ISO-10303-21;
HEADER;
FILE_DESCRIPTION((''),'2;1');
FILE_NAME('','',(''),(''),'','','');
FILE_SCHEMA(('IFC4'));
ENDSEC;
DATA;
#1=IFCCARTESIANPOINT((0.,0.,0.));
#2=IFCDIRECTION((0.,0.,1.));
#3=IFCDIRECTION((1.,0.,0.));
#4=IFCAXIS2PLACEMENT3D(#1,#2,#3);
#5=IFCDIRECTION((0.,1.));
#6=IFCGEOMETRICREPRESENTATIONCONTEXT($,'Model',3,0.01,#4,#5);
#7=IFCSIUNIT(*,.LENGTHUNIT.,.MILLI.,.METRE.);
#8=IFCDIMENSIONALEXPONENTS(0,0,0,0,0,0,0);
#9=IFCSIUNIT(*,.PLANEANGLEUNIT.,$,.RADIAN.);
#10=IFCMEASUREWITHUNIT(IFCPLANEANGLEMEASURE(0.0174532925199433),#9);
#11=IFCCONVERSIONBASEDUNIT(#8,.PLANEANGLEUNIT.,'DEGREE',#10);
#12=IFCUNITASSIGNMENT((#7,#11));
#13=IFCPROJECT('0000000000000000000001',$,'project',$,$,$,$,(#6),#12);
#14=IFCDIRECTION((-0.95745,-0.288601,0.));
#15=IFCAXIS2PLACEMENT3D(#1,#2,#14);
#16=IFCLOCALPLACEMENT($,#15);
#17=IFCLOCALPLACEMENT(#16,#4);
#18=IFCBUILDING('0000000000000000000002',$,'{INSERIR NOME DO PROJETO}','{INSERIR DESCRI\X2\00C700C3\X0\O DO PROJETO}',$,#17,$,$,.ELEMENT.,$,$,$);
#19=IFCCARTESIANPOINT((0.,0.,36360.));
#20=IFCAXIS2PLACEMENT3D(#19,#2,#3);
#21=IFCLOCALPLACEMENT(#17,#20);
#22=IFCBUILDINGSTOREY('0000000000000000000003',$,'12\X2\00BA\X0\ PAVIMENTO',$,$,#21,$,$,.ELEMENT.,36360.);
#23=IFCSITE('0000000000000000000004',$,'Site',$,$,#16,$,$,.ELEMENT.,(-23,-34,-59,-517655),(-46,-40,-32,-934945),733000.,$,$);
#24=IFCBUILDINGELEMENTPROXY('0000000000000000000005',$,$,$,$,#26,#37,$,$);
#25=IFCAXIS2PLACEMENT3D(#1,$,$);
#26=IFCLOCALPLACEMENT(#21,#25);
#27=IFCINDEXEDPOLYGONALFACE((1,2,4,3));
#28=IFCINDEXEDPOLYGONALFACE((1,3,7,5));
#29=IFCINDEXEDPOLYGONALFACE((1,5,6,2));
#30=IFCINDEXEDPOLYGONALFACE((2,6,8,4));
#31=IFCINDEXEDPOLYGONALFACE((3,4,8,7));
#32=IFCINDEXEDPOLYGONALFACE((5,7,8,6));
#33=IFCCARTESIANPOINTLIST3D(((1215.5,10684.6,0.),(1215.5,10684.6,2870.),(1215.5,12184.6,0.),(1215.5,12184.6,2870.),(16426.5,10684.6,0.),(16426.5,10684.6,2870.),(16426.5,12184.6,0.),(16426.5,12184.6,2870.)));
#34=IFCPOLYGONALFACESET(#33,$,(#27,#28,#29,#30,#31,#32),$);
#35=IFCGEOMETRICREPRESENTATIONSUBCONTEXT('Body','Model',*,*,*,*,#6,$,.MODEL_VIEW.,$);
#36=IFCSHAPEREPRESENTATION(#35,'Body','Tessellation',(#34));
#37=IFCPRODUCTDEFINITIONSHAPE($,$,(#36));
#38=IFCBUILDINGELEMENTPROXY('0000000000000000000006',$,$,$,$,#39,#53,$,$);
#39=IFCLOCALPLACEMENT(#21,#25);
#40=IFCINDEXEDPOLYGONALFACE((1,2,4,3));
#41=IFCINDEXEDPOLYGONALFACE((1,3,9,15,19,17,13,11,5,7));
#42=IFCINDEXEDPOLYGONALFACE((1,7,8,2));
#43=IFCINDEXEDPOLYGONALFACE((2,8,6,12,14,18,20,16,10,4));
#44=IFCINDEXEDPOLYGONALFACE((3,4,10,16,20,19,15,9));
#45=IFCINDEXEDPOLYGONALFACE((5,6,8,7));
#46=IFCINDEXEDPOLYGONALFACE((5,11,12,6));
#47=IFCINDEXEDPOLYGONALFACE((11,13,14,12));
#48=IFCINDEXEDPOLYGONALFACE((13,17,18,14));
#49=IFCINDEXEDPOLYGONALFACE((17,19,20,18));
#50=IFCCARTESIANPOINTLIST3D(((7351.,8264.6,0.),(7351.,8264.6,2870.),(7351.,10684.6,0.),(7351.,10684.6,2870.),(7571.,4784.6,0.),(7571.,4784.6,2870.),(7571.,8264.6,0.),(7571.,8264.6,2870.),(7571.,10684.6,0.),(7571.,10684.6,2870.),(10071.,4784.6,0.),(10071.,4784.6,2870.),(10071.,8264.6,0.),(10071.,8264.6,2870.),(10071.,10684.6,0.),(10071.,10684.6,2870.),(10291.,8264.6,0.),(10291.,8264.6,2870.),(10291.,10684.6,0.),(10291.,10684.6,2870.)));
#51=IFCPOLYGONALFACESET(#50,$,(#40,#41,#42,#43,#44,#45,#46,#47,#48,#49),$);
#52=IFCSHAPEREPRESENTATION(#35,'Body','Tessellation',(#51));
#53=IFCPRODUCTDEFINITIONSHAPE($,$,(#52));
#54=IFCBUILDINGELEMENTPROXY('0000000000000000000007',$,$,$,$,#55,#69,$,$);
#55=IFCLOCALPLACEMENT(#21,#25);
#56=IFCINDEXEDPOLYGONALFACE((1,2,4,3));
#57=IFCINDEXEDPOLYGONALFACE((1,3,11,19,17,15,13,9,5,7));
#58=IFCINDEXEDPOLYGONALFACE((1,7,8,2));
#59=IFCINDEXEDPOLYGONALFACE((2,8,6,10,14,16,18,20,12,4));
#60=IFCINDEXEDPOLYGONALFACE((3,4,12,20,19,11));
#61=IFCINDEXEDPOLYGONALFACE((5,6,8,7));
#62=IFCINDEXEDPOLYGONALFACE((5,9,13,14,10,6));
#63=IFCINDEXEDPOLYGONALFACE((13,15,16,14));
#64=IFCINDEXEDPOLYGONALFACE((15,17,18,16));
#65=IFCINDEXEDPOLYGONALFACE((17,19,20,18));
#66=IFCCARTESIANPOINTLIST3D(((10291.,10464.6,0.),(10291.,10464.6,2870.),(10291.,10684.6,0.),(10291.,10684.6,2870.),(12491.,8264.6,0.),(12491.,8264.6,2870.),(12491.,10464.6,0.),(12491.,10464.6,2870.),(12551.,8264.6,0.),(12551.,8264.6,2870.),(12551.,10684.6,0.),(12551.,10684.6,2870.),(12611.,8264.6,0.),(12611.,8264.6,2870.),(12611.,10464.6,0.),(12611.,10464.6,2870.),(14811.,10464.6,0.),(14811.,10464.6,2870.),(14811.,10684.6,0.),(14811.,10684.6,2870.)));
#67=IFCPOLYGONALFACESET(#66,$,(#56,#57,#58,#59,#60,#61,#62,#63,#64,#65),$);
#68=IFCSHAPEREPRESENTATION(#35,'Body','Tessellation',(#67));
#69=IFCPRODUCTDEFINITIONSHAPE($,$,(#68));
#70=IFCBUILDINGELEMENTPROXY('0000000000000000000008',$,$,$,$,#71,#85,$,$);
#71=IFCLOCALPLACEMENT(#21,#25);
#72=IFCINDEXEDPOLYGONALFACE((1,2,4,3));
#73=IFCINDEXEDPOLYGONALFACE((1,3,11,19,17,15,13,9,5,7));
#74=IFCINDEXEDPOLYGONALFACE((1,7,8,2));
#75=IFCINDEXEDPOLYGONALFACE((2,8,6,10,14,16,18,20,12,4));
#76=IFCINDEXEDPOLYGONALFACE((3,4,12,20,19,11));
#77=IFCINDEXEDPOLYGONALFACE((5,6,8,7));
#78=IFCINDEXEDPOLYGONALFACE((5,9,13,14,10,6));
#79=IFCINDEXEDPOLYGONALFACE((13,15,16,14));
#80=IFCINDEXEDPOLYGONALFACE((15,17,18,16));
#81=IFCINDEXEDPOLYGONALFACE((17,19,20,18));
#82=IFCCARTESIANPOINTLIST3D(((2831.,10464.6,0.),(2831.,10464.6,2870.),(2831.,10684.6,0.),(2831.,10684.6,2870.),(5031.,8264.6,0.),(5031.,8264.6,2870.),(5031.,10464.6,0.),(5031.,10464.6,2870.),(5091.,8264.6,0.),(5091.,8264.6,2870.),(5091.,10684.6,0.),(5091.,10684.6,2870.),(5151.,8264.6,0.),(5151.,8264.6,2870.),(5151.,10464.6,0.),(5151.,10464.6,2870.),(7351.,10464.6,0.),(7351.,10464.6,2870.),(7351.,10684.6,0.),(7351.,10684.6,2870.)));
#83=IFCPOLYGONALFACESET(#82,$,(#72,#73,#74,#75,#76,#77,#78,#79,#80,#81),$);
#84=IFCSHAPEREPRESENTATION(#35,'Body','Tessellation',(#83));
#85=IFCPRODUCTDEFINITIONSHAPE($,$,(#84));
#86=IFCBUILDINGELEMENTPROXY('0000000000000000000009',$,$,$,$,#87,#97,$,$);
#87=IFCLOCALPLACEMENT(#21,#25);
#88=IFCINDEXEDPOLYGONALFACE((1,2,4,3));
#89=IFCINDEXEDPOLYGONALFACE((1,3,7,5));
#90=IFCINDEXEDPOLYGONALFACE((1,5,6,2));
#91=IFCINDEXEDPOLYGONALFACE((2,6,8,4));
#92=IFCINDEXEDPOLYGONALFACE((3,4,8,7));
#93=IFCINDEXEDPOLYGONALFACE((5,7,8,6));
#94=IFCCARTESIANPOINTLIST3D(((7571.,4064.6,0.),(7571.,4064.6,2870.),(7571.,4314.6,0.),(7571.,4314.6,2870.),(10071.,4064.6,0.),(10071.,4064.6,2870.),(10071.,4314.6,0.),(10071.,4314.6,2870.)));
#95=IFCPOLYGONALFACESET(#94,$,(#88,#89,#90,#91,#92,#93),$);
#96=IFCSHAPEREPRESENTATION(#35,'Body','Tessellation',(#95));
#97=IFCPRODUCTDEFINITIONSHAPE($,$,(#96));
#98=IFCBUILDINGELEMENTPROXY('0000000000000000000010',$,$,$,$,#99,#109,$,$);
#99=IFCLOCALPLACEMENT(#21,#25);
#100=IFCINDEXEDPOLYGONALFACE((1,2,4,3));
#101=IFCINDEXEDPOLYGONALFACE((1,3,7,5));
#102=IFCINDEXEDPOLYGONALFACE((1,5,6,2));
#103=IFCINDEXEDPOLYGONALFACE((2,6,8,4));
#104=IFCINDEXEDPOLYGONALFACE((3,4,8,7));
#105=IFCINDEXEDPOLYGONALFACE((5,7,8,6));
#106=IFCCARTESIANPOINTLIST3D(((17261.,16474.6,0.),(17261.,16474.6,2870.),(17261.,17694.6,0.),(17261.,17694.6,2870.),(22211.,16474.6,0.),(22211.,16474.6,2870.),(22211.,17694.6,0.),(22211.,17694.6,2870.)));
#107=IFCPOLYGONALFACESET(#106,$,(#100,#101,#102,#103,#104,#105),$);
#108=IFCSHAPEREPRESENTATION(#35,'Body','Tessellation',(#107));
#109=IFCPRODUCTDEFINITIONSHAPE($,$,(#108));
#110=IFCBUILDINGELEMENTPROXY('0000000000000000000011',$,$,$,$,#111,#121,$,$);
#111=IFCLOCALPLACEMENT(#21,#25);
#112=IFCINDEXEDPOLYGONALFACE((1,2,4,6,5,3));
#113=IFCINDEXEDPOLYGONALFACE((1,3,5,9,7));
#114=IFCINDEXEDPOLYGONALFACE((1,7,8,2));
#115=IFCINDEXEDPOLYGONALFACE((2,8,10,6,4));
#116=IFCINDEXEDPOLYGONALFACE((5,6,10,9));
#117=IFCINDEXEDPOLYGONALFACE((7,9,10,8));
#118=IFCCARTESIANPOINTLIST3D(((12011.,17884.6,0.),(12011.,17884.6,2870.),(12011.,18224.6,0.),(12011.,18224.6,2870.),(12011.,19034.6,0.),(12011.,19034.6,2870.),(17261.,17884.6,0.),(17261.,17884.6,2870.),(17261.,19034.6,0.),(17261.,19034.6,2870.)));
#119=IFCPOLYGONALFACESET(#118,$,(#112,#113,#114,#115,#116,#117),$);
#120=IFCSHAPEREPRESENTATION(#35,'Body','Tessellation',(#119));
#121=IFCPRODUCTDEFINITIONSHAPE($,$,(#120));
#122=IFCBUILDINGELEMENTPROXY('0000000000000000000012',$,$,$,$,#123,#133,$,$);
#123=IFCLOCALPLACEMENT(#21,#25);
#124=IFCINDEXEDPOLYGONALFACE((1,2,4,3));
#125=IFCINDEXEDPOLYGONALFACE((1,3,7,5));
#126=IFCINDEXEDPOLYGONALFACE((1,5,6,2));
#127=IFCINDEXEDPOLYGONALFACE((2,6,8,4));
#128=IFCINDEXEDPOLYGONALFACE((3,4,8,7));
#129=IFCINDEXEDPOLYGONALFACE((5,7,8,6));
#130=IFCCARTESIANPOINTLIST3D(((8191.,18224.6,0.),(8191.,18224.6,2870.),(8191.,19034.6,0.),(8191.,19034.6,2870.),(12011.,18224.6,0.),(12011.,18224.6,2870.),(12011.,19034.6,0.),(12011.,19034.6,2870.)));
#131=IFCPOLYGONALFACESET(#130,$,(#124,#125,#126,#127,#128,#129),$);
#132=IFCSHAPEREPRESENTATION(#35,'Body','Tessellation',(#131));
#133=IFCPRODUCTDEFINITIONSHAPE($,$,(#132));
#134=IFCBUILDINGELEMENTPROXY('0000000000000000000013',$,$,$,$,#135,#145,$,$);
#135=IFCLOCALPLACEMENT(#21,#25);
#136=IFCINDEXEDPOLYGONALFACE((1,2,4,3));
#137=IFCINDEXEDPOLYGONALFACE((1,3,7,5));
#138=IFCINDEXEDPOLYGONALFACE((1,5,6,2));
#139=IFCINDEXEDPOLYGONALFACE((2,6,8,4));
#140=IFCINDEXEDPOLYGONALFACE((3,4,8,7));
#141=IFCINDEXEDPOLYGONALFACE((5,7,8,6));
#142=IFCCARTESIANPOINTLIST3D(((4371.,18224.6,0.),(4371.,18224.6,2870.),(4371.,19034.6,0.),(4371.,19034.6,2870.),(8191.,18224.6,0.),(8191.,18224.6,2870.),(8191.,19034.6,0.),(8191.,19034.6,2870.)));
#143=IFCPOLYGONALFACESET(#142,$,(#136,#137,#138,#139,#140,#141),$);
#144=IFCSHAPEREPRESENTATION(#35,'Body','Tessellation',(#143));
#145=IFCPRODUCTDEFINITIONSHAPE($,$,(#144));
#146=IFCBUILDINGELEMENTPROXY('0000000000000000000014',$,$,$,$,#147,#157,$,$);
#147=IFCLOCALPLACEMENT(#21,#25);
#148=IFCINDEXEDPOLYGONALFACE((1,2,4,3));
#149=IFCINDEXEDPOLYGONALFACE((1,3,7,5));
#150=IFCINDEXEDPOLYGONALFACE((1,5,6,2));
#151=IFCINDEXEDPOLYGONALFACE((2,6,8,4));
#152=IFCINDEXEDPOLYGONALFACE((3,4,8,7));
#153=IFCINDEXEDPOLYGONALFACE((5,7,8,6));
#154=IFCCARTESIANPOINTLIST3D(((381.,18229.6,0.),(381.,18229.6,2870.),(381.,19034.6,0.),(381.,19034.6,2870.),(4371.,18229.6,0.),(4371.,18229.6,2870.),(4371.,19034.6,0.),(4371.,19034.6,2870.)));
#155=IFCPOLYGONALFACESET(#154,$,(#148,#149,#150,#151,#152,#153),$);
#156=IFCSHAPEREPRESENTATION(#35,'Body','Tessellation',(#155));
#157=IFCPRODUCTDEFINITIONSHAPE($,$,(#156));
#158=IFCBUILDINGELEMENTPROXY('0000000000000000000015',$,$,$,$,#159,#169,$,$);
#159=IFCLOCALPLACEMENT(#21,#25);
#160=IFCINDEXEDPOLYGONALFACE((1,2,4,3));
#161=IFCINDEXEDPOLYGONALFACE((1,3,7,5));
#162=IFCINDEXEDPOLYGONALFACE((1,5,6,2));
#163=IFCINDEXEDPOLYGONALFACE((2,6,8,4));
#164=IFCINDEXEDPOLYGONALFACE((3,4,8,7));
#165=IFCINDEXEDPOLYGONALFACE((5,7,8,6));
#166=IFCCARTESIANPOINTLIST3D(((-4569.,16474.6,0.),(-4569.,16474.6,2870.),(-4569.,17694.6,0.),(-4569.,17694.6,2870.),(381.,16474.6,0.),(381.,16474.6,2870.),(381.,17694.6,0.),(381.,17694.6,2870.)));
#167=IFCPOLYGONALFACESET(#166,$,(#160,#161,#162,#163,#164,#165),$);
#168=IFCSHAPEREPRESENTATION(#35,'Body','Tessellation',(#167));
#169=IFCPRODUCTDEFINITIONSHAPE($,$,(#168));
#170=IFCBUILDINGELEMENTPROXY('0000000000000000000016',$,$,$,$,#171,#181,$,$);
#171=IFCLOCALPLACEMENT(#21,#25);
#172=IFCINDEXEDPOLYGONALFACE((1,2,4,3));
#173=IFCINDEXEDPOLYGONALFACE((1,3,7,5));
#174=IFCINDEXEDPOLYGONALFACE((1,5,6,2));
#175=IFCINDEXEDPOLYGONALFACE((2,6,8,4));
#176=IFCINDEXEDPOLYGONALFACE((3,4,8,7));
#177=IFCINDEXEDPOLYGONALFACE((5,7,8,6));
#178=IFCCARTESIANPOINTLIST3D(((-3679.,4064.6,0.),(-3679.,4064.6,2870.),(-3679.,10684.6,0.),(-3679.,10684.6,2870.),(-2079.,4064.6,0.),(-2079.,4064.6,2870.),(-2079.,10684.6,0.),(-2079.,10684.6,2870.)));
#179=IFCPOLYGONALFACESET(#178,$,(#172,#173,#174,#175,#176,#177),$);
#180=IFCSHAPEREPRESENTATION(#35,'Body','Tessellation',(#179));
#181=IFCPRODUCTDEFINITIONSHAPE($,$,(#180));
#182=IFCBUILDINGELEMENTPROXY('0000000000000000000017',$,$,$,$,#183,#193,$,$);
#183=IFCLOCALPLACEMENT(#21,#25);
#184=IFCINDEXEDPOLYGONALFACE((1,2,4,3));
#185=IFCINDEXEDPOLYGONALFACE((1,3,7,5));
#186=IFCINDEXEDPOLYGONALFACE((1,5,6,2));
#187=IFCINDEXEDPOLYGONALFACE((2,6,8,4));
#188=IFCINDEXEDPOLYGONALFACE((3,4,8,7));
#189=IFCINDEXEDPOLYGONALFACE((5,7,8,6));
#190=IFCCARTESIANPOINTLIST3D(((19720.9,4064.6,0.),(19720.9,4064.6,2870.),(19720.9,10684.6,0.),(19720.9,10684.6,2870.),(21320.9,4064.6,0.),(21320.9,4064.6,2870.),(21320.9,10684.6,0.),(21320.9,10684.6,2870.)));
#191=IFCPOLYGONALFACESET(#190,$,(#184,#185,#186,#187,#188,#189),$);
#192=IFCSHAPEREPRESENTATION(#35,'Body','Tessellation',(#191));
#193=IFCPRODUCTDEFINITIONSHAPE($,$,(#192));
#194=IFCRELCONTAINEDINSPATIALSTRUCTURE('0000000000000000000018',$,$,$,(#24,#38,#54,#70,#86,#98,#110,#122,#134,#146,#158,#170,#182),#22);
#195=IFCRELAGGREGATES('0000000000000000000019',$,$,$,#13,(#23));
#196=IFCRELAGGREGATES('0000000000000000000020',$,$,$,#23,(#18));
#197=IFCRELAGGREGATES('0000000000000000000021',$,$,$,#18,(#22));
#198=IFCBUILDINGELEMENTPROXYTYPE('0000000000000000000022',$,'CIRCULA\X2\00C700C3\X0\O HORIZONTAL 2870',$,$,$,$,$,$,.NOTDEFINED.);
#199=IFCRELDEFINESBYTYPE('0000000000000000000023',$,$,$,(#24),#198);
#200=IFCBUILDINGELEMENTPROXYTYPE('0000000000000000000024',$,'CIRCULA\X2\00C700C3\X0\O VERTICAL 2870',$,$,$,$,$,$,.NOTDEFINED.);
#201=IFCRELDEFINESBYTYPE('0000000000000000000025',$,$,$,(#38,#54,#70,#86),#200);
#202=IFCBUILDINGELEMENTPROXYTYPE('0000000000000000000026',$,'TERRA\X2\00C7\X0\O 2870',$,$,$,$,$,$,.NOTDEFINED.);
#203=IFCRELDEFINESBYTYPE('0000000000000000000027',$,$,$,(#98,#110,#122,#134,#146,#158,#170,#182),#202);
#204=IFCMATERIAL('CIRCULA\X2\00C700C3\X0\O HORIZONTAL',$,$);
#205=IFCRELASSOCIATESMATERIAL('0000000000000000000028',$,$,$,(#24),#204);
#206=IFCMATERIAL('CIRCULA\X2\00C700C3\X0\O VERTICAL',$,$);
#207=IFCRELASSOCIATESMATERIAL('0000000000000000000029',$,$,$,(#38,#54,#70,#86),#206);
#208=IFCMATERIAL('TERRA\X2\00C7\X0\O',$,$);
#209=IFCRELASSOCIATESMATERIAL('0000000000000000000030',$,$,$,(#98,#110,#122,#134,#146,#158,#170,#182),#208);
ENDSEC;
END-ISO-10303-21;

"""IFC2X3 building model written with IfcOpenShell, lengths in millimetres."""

from ifc_helpers import new_model, entity, si_unit, converted_unit, direction, frame, origin_with_axes, place, context, subcontext, project, spatial, polyline, outline, extrude, material, type_object, element, save


model = new_model("IFC2X3")

# Units and contexts
model_context = context("Model", 3, precision=0.01, world=origin_with_axes(), true_north=direction((0.0, 1.0)))
body_context = subcontext(model_context, "Body", "Model", "MODEL_VIEW")
ifc_project = project(units=[si_unit("LENGTHUNIT", "METRE", prefix="MILLI"), converted_unit("PLANEANGLEUNIT", "DEGREE", entity("IfcPlaneAngleMeasure", 0.0174532925199433), si_unit("PLANEANGLEUNIT", "RADIAN"), dimensions=[0, 0, 0, 0, 0, 0, 0])], contexts=[model_context])

# Site, building, storey
site_placement = place(None, frame((0.0, 0.0, 0.0), z_axis=(0.0, 0.0, 1.0), x_axis=(-0.95745, -0.288601, 0.0)))
site = spatial("IfcSite", under=ifc_project, at=site_placement, Name="Site", CompositionType="ELEMENT", RefLatitude=(-23, -34, -59, -517655), RefLongitude=(-46, -40, -32, -934945), RefElevation=733000.0)
building_placement = place(site_placement, origin_with_axes())
building = spatial("IfcBuilding", under=site, at=building_placement, Name="{INSERIR NOME DO PROJETO}", Description="{INSERIR DESCRIÇÃO DO PROJETO}", CompositionType="ELEMENT")
storey_placement = place(building_placement, frame((0.0, 0.0, 36360.0), z_axis=(0.0, 0.0, 1.0), x_axis=(1.0, 0.0, 0.0)))
storey = spatial("IfcBuildingStorey", under=building, at=storey_placement, Name="12º PAVIMENTO", CompositionType="ELEMENT", Elevation=36360.0)

# Building element proxies
ifc_material_1 = material(Name="CIRCULAÇÃO HORIZONTAL")
building_element_proxy_type_1 = type_object("IfcBuildingElementProxyType", Name="CIRCULAÇÃO HORIZONTAL 2870", PredefinedType="NOTDEFINED")
proxy_1_placement = place(storey_placement, frame((1215.5, 10684.6, 0.0), z_axis=(0.0, 0.0, 1.0), x_axis=(1.0, 0.0, 0.0)))
element("IfcBuildingElementProxy", 1, at=proxy_1_placement, inside=storey, type_object=building_element_proxy_type_1, material=ifc_material_1, context=body_context, shape_type="SweptSolid", body=[
    extrude(outline(polyline([(0.0, 0.0), (15211.0, 0.0), (15211.0, 1500.0), (0.0, 1500.0), (0.0, 0.0)])), origin_with_axes(), (0.0, 0.0, 1.0), 2870.0),
])
ifc_material_2 = material(Name="CIRCULAÇÃO VERTICAL")
building_element_proxy_type_2 = type_object("IfcBuildingElementProxyType", Name="CIRCULAÇÃO VERTICAL 2870", PredefinedType="NOTDEFINED")
proxy_2_placement = place(storey_placement, frame((7351.0, 10684.6, 0.0), z_axis=(0.0, 0.0, 1.0), x_axis=(1.0, 0.0, 0.0)))
element("IfcBuildingElementProxy", 2, at=proxy_2_placement, inside=storey, type_object=building_element_proxy_type_2, material=ifc_material_2, context=body_context, shape_type="SweptSolid", body=[
    extrude(outline(polyline([(0.0, 0.0), (0.0, -2420.0), (220.0, -2420.0), (220.0, -5900.0), (2720.0, -5900.0), (2720.0, -2420.0), (2940.0, -2420.0), (2940.0, 0.0), (2720.0, 0.0), (220.0, 0.0), (0.0, 0.0)])), origin_with_axes(), (0.0, 0.0, 1.0), 2870.0),
])
proxy_3_placement = place(storey_placement, frame((10291.0, 10684.6, 0.0), z_axis=(0.0, 0.0, 1.0), x_axis=(1.0, 0.0, 0.0)))
element("IfcBuildingElementProxy", 3, at=proxy_3_placement, inside=storey, type_object=building_element_proxy_type_2, material=ifc_material_2, context=body_context, shape_type="SweptSolid", body=[
    extrude(outline(polyline([(0.0, 0.0), (0.0, -220.0), (2200.0, -220.0), (2200.0, -2420.0), (2260.0, -2420.0), (2320.0, -2420.0), (2320.0, -220.0), (4520.0, -220.0), (4520.0, 0.0), (2260.0, 0.0), (0.0, 0.0)])), origin_with_axes(), (0.0, 0.0, 1.0), 2870.0),
])
proxy_4_placement = place(storey_placement, frame((5091.0, 10684.6, 0.0), z_axis=(0.0, 0.0, 1.0), x_axis=(1.0, 0.0, 0.0)))
element("IfcBuildingElementProxy", 4, at=proxy_4_placement, inside=storey, type_object=building_element_proxy_type_2, material=ifc_material_2, context=body_context, shape_type="SweptSolid", body=[
    extrude(outline(polyline([(0.0, 0.0), (-2260.0, 0.0), (-2260.0, -220.0), (-60.0, -220.0), (-60.0, -2420.0), (0.0, -2420.0), (60.0, -2420.0), (60.0, -220.0), (2260.0, -220.0), (2260.0, 0.0), (0.0, 0.0)])), origin_with_axes(), (0.0, 0.0, 1.0), 2870.0),
])
proxy_5_placement = place(storey_placement, frame((7571.0, 4064.6, 0.0), z_axis=(0.0, 0.0, 1.0), x_axis=(1.0, 0.0, 0.0)))
element("IfcBuildingElementProxy", 5, at=proxy_5_placement, inside=storey, type_object=building_element_proxy_type_2, material=ifc_material_2, context=body_context, shape_type="SweptSolid", body=[
    extrude(outline(polyline([(0.0, 0.0), (2500.0, 0.0), (2500.0, 250.0), (0.0, 250.0), (0.0, 0.0)])), origin_with_axes(), (0.0, 0.0, 1.0), 2870.0),
])
ifc_material_3 = material(Name="TERRAÇO")
building_element_proxy_type_3 = type_object("IfcBuildingElementProxyType", Name="TERRAÇO 2870", PredefinedType="NOTDEFINED")
proxy_6_placement = place(storey_placement, frame((17261.0, 16474.6, 0.0), z_axis=(0.0, 0.0, 1.0), x_axis=(1.0, 0.0, 0.0)))
element("IfcBuildingElementProxy", 6, at=proxy_6_placement, inside=storey, type_object=building_element_proxy_type_3, material=ifc_material_3, context=body_context, shape_type="SweptSolid", body=[
    extrude(outline(polyline([(0.0, 0.0), (4950.0, 0.0), (4950.0, 1220.0), (0.0, 1220.0), (0.0, 0.0)])), origin_with_axes(), (0.0, 0.0, 1.0), 2870.0),
])
proxy_7_placement = place(storey_placement, frame((12011.0, 19034.6, 0.0), z_axis=(0.0, 0.0, 1.0), x_axis=(1.0, 0.0, 0.0)))
element("IfcBuildingElementProxy", 7, at=proxy_7_placement, inside=storey, type_object=building_element_proxy_type_3, material=ifc_material_3, context=body_context, shape_type="SweptSolid", body=[
    extrude(outline(polyline([(0.0, 0.0), (0.0, -810.0), (0.0, -1150.0), (5250.0, -1150.0), (5250.0, 0.0), (0.0, 0.0)])), origin_with_axes(), (0.0, 0.0, 1.0), 2870.0),
])
for number, where, z_axis, x_axis in (
    (8, (8191.0, 18224.6, 0.0), (0.0, 0.0, 1.0), (1.0, 0.0, 0.0)),
    (9, (4371.0, 18224.6, 0.0), (0.0, 0.0, 1.0), (1.0, 0.0, 0.0)),
):
    element("IfcBuildingElementProxy", number, at=place(storey_placement, frame(where, z_axis=z_axis, x_axis=x_axis)), inside=storey, type_object=building_element_proxy_type_3, material=ifc_material_3, context=body_context, shape_type="SweptSolid", body=[
        extrude(outline(polyline([(0.0, 0.0), (3820.0, 0.0), (3820.0, 810.0), (0.0, 810.0), (0.0, 0.0)])), origin_with_axes(), (0.0, 0.0, 1.0), 2870.0),
    ])
proxy_8_placement = place(storey_placement, frame((381.0, 19034.6, 0.0), z_axis=(0.0, 0.0, 1.0), x_axis=(1.0, 0.0, 0.0)))
element("IfcBuildingElementProxy", 10, at=proxy_8_placement, inside=storey, type_object=building_element_proxy_type_3, material=ifc_material_3, context=body_context, shape_type="SweptSolid", body=[
    extrude(outline(polyline([(0.0, 0.0), (0.0, -805.0), (3990.0, -805.0), (3990.0, 0.0), (0.0, 0.0)])), origin_with_axes(), (0.0, 0.0, 1.0), 2870.0),
])
proxy_9_placement = place(storey_placement, frame((381.0, 17694.6, 0.0), z_axis=(0.0, 0.0, 1.0), x_axis=(1.0, 0.0, 0.0)))
element("IfcBuildingElementProxy", 11, at=proxy_9_placement, inside=storey, type_object=building_element_proxy_type_3, material=ifc_material_3, context=body_context, shape_type="SweptSolid", body=[
    extrude(outline(polyline([(0.0, 0.0), (-4950.0, 0.0), (-4950.0, -1220.0), (0.0, -1220.0), (0.0, 0.0)])), origin_with_axes(), (0.0, 0.0, 1.0), 2870.0),
])
proxy_10_placement = place(storey_placement, frame((-3679.0, 4064.6, 0.0), z_axis=(0.0, 0.0, 1.0), x_axis=(1.0, 0.0, 0.0)))
element("IfcBuildingElementProxy", 12, at=proxy_10_placement, inside=storey, type_object=building_element_proxy_type_3, material=ifc_material_3, context=body_context, shape_type="SweptSolid", body=[
    extrude(outline(polyline([(0.0, 0.0), (1600.0, 0.0), (1600.0, 6620.0), (0.0, 6620.0), (0.0, 0.0)])), origin_with_axes(), (0.0, 0.0, 1.0), 2870.0),
])
proxy_11_placement = place(storey_placement, frame((21320.9, 4064.6, 0.0), z_axis=(0.0, 0.0, 1.0), x_axis=(1.0, 0.0, 0.0)))
element("IfcBuildingElementProxy", 13, at=proxy_11_placement, inside=storey, type_object=building_element_proxy_type_3, material=ifc_material_3, context=body_context, shape_type="SweptSolid", body=[
    extrude(outline(polyline([(0.0, 0.0), (0.0, 6620.0), (-1600.0, 6620.0), (-1600.0, 0.0), (0.0, 0.0)])), origin_with_axes(), (0.0, 0.0, 1.0), 2870.0),
])

save(model, "model.ifc")
